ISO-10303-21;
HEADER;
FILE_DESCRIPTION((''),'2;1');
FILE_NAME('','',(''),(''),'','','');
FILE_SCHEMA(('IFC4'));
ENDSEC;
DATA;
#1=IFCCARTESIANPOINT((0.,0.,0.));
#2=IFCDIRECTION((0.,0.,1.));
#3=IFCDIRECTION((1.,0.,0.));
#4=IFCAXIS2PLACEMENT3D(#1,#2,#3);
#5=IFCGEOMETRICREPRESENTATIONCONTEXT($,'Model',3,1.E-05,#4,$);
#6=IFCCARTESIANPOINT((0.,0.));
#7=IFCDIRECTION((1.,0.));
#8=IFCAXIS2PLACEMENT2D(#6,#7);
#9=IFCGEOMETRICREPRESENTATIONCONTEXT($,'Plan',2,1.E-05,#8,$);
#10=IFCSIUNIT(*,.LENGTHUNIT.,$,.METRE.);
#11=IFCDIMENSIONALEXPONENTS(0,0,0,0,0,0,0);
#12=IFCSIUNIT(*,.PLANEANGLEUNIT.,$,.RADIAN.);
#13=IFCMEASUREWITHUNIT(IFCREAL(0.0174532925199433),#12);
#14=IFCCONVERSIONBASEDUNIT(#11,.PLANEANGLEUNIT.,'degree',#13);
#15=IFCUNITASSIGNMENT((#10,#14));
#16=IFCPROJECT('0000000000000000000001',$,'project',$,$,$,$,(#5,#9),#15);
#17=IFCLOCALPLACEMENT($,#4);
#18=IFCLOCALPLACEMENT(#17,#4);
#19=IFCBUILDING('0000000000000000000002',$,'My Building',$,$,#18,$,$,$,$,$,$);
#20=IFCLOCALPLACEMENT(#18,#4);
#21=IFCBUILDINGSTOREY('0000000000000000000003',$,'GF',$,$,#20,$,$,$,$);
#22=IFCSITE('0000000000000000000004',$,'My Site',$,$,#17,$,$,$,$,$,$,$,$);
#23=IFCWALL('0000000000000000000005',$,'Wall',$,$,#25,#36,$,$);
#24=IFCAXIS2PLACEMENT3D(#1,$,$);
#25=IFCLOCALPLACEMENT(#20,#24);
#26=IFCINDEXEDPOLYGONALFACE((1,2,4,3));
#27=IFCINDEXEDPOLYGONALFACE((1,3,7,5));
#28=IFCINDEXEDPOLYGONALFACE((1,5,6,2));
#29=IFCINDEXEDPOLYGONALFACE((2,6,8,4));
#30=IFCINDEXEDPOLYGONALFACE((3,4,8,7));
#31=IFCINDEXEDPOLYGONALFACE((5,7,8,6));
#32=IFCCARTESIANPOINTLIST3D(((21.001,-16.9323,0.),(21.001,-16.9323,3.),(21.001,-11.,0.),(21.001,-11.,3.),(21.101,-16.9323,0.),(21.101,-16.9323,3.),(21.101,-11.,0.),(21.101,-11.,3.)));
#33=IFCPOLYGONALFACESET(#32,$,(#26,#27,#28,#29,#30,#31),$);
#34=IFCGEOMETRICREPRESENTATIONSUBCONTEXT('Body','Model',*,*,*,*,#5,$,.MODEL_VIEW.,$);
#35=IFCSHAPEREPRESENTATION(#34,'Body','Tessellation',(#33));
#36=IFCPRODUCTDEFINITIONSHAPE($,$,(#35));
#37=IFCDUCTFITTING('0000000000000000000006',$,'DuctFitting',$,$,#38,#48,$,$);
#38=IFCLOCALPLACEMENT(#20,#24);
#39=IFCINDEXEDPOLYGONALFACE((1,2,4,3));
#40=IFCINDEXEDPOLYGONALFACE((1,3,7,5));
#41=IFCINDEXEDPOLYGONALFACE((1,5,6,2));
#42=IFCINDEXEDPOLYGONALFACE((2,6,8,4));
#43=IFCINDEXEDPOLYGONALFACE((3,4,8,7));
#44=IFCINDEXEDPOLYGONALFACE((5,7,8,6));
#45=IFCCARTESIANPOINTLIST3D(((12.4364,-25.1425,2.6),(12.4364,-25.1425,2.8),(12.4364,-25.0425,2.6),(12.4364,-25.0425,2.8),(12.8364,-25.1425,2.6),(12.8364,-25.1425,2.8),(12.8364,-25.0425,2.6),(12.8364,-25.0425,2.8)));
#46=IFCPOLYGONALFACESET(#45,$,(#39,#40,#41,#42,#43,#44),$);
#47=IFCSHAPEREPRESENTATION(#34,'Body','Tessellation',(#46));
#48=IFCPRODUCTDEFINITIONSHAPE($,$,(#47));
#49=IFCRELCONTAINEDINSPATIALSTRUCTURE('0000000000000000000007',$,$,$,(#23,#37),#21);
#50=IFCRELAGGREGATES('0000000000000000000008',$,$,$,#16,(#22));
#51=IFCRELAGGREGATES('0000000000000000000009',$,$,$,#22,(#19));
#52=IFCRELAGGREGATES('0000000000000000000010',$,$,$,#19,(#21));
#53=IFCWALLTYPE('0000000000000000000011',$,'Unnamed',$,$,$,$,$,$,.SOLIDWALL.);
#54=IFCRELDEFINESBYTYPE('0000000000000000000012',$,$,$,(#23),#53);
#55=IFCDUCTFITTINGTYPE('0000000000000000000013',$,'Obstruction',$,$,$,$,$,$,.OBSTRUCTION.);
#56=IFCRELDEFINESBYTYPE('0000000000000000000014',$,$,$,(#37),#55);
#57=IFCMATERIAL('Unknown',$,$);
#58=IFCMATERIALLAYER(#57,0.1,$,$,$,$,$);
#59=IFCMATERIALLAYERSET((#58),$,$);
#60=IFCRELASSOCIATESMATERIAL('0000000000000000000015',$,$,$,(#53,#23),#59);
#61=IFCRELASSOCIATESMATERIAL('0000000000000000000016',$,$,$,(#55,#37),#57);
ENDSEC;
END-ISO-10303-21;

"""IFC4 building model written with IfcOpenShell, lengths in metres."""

from ifc_helpers import new_model, entity, si_unit, converted_unit, frame, origin_with_axes, origin_2d_with_axis, place, context, subcontext, project, spatial, line, indexed_curve, rectangle, outline, extrude, material, layer, layer_set, layer_usage, material_profile, profile_set, profile_usage, type_object, element, save


model = new_model("IFC4")

# Units and contexts
model_context = context("Model", 3, precision=1e-05, world=origin_with_axes())
plan_context = context("Plan", 2, precision=1e-05, world=origin_2d_with_axis())
body_context_1 = subcontext(model_context, "Body", "Model", "MODEL_VIEW")
ifc_project = project(units=[si_unit("LENGTHUNIT", "METRE"), converted_unit("PLANEANGLEUNIT", "degree", entity("IfcReal", 0.0174532925199433), si_unit("PLANEANGLEUNIT", "RADIAN"), dimensions=[0, 0, 0, 0, 0, 0, 0])], contexts=[model_context, plan_context])

# Site, building, storey
site_placement = place(None, origin_with_axes())
site = spatial("IfcSite", under=ifc_project, at=site_placement, Name="My Site")
building_placement = place(site_placement, origin_with_axes())
building = spatial("IfcBuilding", under=site, at=building_placement, Name="My Building")
storey_placement = place(building_placement, origin_with_axes())
storey = spatial("IfcBuildingStorey", under=building, at=storey_placement, Name="GF")

# Shared definitions
ifc_material = material(Name="Unknown")
ifc_layer = layer(ifc_material, 0.1)
ifc_layer_set = layer_set([ifc_layer])
wall_type = type_object("IfcWallType", Name="Unnamed", PredefinedType="SOLIDWALL", material=ifc_layer_set)

# Wall
ifc_layer_usage_1 = layer_usage(ifc_layer_set, "AXIS2", "POSITIVE", 0.0)
wall_1_placement = place(storey_placement, frame((21.101, -16.9323, 0.0), z_axis=(0.0, 0.0, 1.0), x_axis=(0.0, 1.0, 0.0)))
element("IfcWall", 1, at=wall_1_placement, inside=storey, type_object=wall_type, material=ifc_layer_usage_1, Name="Wall", context=body_context_1, shape_type="SweptSolid", body=[
    extrude(outline(indexed_curve([(0.0, 0.0), (0.0, 0.1), (5.9323, 0.1), (5.9323, 0.0)], segments=[line(1, 2, 3, 4, 1)])), origin_with_axes(), (0.0, 0.0, 1.0), 3.0),
])

# Duct fitting
ifc_material_profile = material_profile(ifc_material, rectangle(XDim=0.4, YDim=0.2))
ifc_profile_set = profile_set([ifc_material_profile])
ifc_profile_usage = profile_usage(ifc_profile_set, cardinal=5)
duct_fitting_type = type_object("IfcDuctFittingType", Name="Obstruction", PredefinedType="OBSTRUCTION", material=ifc_profile_set)
duct_fitting_placement = place(storey_placement, frame((12.6364, -25.0425, 2.7), z_axis=(0.0, -1.0, 0.0), x_axis=(1.0, 0.0, 0.0)))
element("IfcDuctFitting", 2, at=duct_fitting_placement, inside=storey, type_object=duct_fitting_type, material=ifc_profile_usage, Name="DuctFitting", context=body_context_1, shape_type="SweptSolid", body=[
    extrude(rectangle(XDim=0.4, YDim=0.2), origin_with_axes(), (0.0, 0.0, 1.0), 0.1),
])

save(model, "model.ifc")
